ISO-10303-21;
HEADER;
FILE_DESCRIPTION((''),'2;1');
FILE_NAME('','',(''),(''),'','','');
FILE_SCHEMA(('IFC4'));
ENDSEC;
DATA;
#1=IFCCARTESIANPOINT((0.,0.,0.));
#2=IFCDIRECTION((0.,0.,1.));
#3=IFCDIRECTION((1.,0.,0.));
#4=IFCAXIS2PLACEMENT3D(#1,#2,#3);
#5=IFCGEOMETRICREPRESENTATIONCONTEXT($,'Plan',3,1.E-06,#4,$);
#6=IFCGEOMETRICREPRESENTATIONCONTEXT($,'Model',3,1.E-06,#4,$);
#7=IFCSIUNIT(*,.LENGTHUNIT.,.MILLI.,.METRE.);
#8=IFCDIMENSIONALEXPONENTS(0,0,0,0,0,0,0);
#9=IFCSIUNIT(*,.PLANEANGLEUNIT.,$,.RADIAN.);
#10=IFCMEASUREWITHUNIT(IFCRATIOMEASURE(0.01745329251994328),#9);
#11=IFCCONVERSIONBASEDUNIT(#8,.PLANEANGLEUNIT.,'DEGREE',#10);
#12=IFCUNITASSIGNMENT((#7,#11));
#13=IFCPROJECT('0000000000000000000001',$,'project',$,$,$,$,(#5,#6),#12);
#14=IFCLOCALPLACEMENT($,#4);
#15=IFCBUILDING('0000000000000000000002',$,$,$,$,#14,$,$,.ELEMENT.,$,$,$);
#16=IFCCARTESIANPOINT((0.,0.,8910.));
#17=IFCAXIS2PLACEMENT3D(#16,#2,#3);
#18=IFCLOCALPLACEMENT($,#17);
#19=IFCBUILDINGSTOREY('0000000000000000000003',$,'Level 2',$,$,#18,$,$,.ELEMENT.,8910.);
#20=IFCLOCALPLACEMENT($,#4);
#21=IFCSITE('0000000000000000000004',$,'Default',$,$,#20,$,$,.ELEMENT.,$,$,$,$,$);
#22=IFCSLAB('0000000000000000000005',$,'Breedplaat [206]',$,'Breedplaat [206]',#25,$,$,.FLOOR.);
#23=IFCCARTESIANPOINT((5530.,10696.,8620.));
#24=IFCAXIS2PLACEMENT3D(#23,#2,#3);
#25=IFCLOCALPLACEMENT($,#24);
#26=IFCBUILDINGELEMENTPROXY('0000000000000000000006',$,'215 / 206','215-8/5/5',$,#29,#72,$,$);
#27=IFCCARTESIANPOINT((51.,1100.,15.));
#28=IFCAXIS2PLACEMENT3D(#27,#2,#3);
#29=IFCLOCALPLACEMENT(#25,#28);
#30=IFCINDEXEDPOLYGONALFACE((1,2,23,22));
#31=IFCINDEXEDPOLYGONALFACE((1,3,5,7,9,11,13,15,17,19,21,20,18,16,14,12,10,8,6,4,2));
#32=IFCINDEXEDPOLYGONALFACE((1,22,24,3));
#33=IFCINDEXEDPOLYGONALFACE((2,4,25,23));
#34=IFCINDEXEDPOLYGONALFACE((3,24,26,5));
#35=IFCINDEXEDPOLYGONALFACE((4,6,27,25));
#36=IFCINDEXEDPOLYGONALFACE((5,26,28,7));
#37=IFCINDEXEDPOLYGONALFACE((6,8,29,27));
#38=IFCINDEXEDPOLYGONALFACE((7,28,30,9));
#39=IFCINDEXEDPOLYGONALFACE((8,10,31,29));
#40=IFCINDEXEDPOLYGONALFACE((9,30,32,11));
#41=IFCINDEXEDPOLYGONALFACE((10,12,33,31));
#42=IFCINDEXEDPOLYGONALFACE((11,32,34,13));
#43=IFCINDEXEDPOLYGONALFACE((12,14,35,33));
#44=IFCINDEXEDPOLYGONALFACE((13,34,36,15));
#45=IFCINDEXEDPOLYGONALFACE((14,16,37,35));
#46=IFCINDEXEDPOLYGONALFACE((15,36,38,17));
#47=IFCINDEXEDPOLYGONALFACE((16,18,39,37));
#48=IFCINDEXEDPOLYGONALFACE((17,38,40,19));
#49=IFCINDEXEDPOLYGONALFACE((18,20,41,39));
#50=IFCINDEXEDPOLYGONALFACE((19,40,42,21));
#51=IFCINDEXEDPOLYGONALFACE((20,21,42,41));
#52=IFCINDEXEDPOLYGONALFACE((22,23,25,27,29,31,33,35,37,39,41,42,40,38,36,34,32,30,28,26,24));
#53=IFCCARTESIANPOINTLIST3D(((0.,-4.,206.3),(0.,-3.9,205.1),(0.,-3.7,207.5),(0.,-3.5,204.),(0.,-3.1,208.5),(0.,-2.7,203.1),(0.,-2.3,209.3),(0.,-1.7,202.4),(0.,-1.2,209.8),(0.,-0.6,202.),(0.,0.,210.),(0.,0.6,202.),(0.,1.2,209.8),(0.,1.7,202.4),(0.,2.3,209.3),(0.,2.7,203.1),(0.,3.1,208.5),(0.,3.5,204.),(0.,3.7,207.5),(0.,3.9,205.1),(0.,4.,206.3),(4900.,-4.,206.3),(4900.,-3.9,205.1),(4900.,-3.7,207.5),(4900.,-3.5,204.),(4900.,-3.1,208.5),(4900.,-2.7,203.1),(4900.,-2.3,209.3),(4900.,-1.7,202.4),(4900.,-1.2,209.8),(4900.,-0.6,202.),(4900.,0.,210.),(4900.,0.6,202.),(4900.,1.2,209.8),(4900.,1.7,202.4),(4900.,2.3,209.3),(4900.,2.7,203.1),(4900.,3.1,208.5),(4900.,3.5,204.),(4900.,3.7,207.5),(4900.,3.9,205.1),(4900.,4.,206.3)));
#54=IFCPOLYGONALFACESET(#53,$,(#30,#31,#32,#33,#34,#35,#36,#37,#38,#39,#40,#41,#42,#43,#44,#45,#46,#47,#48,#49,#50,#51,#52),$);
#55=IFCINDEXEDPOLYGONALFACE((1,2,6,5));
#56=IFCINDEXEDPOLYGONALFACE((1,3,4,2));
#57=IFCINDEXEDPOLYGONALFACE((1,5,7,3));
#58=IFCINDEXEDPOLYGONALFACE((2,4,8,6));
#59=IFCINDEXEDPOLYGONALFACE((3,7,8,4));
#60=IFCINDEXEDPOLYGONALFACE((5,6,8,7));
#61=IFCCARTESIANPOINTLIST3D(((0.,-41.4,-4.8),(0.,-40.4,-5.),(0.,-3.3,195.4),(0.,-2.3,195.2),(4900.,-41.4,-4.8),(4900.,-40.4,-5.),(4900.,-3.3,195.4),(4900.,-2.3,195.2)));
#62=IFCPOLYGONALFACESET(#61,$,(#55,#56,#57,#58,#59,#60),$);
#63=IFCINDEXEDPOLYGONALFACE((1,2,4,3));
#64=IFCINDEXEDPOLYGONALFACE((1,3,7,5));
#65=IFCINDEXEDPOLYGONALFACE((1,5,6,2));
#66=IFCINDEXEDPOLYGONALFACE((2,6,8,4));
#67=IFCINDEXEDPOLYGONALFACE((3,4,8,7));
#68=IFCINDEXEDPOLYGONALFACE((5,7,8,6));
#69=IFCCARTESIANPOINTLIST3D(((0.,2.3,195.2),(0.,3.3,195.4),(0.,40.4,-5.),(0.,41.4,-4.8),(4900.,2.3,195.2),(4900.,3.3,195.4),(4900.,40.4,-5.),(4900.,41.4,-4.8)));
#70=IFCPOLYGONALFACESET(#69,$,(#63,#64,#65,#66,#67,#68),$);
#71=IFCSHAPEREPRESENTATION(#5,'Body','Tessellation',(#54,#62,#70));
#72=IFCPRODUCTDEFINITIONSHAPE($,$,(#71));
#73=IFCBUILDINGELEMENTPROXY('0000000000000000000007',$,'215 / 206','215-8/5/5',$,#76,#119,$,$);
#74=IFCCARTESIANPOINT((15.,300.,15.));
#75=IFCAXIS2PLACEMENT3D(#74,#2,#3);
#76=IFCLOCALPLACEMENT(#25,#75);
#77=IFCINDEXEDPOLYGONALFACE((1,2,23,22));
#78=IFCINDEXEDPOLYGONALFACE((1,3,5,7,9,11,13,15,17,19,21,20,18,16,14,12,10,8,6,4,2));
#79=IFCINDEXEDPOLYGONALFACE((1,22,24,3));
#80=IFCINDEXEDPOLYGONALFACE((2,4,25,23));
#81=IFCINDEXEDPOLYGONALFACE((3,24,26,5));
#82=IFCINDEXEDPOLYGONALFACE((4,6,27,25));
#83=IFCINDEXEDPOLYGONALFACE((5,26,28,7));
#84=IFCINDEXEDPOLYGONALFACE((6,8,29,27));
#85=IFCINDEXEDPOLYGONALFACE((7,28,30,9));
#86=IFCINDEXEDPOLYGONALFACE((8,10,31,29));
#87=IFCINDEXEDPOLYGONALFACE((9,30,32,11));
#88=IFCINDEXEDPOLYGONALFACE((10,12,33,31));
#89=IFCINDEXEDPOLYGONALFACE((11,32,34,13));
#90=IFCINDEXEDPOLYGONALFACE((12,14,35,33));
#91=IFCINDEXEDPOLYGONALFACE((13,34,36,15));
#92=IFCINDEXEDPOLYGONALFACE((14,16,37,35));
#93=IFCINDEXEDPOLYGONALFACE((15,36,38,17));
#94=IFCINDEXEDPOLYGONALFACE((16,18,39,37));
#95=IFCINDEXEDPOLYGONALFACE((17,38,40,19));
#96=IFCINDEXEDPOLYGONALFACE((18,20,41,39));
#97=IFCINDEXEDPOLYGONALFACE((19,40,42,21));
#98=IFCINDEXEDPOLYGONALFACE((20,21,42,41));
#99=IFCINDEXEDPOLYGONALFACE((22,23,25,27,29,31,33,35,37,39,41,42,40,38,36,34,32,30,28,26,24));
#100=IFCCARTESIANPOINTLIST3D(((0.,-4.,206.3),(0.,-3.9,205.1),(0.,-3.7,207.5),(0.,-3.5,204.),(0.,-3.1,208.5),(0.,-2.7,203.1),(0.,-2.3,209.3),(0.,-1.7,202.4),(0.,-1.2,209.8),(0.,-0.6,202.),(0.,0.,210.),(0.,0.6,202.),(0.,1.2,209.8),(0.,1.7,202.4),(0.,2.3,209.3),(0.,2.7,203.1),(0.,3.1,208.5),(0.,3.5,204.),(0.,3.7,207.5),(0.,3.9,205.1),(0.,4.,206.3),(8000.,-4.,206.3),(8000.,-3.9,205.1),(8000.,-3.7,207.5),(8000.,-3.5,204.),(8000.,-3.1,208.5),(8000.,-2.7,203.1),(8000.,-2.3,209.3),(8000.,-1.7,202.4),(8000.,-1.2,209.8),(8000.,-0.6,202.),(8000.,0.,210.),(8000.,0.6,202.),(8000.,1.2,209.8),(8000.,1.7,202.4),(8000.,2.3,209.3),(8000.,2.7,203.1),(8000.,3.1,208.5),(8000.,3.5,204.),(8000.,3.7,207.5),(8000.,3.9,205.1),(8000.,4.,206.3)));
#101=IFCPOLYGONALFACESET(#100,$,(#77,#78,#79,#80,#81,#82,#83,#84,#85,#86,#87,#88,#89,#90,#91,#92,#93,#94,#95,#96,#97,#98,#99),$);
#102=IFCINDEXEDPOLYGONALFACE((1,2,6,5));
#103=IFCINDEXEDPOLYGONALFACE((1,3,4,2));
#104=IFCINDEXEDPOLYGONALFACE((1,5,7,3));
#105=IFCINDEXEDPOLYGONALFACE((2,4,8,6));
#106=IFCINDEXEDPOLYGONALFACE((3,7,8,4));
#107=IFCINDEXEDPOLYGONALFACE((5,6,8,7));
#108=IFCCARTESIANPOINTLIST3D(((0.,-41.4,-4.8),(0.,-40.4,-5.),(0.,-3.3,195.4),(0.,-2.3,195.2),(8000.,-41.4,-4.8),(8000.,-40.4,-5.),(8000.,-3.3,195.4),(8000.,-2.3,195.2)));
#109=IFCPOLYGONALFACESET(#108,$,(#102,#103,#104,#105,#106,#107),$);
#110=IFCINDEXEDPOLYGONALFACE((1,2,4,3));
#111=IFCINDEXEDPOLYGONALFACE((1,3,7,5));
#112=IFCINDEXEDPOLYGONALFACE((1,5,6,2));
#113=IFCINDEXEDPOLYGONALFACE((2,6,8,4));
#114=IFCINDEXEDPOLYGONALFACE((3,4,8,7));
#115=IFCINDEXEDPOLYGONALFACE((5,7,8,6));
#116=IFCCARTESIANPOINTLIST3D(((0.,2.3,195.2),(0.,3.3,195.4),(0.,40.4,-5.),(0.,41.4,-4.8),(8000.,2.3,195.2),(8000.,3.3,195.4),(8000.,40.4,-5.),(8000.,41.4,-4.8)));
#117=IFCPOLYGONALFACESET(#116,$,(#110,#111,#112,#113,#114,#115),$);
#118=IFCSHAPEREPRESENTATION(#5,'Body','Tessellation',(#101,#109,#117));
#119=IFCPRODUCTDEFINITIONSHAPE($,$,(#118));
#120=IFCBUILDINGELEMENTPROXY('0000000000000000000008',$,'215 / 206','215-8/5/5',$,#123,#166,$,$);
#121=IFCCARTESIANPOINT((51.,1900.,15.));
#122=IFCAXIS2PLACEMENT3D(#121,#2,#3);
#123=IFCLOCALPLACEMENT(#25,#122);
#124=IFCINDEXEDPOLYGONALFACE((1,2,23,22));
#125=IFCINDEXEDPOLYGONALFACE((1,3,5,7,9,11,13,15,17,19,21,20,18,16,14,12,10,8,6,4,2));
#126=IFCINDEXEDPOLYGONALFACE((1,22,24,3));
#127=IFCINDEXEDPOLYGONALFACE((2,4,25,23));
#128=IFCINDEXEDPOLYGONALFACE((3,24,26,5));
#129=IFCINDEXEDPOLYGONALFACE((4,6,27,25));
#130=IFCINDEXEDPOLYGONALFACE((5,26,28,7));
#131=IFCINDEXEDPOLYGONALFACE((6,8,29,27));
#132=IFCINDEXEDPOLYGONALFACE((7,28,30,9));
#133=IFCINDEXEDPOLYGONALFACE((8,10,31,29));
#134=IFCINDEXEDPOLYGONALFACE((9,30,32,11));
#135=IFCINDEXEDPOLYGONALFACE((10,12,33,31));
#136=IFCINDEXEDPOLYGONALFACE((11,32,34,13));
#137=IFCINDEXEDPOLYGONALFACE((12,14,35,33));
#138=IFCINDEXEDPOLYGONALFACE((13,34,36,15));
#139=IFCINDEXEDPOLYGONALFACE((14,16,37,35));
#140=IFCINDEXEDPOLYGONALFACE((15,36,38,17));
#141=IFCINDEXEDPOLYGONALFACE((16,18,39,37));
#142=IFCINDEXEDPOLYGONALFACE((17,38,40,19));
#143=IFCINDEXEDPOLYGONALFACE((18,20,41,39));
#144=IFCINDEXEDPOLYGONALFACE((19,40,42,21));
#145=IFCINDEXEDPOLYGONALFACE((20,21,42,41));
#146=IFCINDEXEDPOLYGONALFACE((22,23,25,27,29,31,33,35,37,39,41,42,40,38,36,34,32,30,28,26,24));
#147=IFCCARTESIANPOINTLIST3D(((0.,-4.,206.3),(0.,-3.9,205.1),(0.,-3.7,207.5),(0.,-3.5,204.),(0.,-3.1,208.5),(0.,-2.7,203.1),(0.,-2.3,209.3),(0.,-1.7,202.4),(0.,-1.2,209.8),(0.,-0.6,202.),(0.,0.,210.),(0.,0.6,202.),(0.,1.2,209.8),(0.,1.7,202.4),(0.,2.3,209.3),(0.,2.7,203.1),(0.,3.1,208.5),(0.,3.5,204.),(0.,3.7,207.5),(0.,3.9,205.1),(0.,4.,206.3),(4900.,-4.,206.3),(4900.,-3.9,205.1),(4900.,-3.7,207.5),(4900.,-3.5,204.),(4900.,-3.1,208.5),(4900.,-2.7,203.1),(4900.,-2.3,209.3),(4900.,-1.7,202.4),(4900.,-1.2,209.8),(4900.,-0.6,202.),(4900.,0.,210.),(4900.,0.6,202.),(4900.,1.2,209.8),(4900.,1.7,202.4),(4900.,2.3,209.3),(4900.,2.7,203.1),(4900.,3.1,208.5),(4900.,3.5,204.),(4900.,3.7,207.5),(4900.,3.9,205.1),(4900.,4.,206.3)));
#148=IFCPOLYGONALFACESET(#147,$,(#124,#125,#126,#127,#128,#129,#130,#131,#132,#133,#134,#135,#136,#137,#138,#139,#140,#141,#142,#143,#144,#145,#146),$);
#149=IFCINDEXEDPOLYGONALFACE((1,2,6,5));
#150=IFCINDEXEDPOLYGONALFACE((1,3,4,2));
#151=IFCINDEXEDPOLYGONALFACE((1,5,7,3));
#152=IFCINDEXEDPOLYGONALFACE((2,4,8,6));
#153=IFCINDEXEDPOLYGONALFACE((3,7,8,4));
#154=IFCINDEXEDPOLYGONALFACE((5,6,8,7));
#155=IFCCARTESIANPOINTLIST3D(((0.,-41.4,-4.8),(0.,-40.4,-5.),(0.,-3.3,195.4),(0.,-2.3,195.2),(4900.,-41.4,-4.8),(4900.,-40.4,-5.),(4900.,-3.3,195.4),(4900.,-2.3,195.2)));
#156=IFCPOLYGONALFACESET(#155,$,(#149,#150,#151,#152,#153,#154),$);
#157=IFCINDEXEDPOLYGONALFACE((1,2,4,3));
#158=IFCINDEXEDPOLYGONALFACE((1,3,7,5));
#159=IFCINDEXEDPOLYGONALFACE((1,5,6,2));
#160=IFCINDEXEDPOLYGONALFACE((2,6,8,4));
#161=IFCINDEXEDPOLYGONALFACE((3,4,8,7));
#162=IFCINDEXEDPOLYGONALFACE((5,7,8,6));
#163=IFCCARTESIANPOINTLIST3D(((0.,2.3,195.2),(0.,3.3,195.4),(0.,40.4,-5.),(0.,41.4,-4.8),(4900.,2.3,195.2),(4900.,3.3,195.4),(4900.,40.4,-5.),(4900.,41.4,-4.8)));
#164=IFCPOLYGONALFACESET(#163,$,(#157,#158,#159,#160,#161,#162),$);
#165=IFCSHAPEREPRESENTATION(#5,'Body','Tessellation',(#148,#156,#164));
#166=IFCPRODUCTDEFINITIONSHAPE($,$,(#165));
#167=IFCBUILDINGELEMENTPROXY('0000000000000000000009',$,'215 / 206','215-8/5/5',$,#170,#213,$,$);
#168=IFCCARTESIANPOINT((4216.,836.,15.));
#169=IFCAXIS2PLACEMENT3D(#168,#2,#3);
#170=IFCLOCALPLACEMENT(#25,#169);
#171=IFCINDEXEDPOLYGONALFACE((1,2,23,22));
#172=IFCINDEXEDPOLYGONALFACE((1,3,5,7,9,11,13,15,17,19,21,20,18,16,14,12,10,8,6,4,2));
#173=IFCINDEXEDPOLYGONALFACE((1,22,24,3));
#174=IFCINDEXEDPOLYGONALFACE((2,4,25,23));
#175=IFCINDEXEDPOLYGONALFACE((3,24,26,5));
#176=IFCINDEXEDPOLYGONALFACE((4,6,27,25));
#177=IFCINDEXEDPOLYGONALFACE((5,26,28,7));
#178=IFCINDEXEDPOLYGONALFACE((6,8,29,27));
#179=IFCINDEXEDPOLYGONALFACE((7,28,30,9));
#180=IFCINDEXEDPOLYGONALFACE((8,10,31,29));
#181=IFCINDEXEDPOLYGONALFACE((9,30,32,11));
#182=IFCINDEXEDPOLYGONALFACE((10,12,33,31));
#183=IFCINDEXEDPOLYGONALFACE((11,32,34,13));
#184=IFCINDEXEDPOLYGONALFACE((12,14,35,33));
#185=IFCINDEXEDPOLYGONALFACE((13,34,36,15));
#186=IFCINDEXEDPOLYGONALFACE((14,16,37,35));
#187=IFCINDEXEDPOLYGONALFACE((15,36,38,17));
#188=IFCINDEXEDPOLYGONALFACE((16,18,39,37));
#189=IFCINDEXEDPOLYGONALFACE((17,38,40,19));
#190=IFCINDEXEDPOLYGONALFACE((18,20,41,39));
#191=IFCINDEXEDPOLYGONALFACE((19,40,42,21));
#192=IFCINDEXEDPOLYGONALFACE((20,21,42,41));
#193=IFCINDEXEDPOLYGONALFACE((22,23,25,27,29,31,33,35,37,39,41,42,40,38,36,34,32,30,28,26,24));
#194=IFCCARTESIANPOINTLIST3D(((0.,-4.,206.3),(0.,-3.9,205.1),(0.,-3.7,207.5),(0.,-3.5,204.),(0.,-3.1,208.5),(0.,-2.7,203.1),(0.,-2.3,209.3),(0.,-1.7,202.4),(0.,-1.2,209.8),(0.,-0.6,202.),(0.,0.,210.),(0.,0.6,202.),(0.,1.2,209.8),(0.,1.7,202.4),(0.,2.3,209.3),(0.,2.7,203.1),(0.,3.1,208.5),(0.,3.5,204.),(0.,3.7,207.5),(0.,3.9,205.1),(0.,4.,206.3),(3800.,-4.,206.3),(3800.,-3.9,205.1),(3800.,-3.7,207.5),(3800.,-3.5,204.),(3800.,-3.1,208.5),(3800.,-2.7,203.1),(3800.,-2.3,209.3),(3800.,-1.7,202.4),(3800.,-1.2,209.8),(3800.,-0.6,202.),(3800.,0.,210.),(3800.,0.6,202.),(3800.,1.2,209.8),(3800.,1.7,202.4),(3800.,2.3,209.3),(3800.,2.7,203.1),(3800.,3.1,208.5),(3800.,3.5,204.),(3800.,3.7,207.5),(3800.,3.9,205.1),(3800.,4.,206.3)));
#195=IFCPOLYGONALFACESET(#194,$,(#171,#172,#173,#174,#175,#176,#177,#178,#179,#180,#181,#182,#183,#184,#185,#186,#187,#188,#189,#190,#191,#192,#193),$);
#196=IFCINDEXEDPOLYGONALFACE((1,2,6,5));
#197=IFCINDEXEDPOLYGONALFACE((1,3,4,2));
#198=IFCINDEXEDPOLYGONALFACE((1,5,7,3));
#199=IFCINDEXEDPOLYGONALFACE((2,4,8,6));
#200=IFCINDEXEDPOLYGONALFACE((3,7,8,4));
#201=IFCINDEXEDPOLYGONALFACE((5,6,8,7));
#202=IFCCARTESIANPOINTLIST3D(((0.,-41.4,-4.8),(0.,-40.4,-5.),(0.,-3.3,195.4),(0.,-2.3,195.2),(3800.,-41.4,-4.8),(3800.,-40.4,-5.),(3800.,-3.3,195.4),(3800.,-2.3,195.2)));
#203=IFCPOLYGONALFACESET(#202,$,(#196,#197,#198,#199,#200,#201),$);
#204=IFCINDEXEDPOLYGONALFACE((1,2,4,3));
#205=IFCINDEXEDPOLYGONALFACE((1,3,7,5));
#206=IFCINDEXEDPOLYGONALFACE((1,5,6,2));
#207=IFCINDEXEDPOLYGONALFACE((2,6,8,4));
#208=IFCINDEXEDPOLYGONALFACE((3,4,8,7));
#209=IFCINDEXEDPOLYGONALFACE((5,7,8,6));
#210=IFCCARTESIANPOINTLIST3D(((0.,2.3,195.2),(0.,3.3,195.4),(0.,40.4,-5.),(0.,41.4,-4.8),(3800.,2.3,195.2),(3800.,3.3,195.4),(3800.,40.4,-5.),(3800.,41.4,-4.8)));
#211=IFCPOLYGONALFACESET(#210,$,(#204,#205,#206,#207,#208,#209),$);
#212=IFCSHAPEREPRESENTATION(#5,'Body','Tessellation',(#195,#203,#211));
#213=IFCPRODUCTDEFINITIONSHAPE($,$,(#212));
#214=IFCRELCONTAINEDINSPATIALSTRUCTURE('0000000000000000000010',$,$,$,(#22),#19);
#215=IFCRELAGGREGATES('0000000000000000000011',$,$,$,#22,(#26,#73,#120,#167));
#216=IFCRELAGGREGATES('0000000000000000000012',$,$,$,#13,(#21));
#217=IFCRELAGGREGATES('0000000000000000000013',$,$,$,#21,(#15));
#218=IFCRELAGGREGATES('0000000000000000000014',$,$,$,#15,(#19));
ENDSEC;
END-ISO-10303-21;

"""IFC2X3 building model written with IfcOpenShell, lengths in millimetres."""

from ifc_helpers import new_model, entity, si_unit, converted_unit, frame, origin_with_axes, origin_2d_with_axis, place, context, project, spatial, rectangle, circle, extrude, element, aggregate, save


model = new_model("IFC2X3")

# Units and contexts
plan_context = context("Plan", 3, precision=1e-06, world=origin_with_axes())
model_context = context("Model", 3, precision=1e-06, world=origin_with_axes())
ifc_project = project(units=[si_unit("LENGTHUNIT", "METRE", prefix="MILLI"), converted_unit("PLANEANGLEUNIT", "DEGREE", entity("IfcRatioMeasure", 0.01745329251994328), si_unit("PLANEANGLEUNIT", "RADIAN"), dimensions=[0, 0, 0, 0, 0, 0, 0])], contexts=[plan_context, model_context])

# Site, building, storey
site_placement = place(None, origin_with_axes())
site = spatial("IfcSite", under=ifc_project, at=site_placement, Name="Default", CompositionType="ELEMENT")
building_placement = place(None, origin_with_axes())
building = spatial("IfcBuilding", under=site, at=building_placement, CompositionType="ELEMENT")
storey_placement = place(None, frame((0.0, 0.0, 8910.0), z_axis=(0.0, 0.0, 1.0), x_axis=(1.0, 0.0, 0.0)))
storey = spatial("IfcBuildingStorey", under=building, at=storey_placement, Name="Level 2", CompositionType="ELEMENT", Elevation=8910.0)

# Slab, building element proxies
slab_1_placement = place(None, frame((5530.0, 10696.0, 8620.0), z_axis=(0.0, 0.0, 1.0), x_axis=(1.0, 0.0, 0.0)))
slab_1 = element("IfcSlab", 1, at=slab_1_placement, inside=storey, Name="Breedplaat [206]", ObjectType="Breedplaat [206]", PredefinedType="FLOOR")
proxy_1_placement = place(slab_1_placement, frame((51.0, 1100.0, 15.0), z_axis=(0.0, 0.0, 1.0), x_axis=(1.0, 0.0, 0.0)))
proxy_1 = element("IfcBuildingElementProxy", 2, at=proxy_1_placement, Name="215 / 206", Description="215-8/5/5", context=plan_context, shape_type="SweptSolid", body=[
    extrude(circle(Radius=4.0, at=origin_2d_with_axis()), frame((0.0, 0.0, 206.0), z_axis=(1.0, 0.0, 0.0), x_axis=(0.0, 0.0, 1.0)), (0.0, 0.0, 1.0), 4900.0),
    extrude(rectangle(XDim=203.8, YDim=1.0, at=origin_2d_with_axis()), frame((0.0, -21.9, 95.2), z_axis=(1.0, 0.0, 0.0), x_axis=(0.0, 0.187112, 0.982339)), (0.0, 0.0, 1.0), 4900.0),
    extrude(rectangle(XDim=203.8, YDim=1.0, at=origin_2d_with_axis()), frame((0.0, 21.9, 95.2), z_axis=(1.0, 0.0, 0.0), x_axis=(0.0, -0.187112, 0.982339)), (0.0, 0.0, 1.0), 4900.0),
])
proxy_2_placement = place(slab_1_placement, frame((15.0, 300.0, 15.0), z_axis=(0.0, 0.0, 1.0), x_axis=(1.0, 0.0, 0.0)))
proxy_2 = element("IfcBuildingElementProxy", 3, at=proxy_2_placement, Name="215 / 206", Description="215-8/5/5", context=plan_context, shape_type="SweptSolid", body=[
    extrude(circle(Radius=4.0, at=origin_2d_with_axis()), frame((0.0, 0.0, 206.0), z_axis=(1.0, 0.0, 0.0), x_axis=(0.0, 0.0, 1.0)), (0.0, 0.0, 1.0), 8000.0),
    extrude(rectangle(XDim=203.8, YDim=1.0, at=origin_2d_with_axis()), frame((0.0, -21.9, 95.2), z_axis=(1.0, 0.0, 0.0), x_axis=(0.0, 0.187112, 0.982339)), (0.0, 0.0, 1.0), 8000.0),
    extrude(rectangle(XDim=203.8, YDim=1.0, at=origin_2d_with_axis()), frame((0.0, 21.9, 95.2), z_axis=(1.0, 0.0, 0.0), x_axis=(0.0, -0.187112, 0.982339)), (0.0, 0.0, 1.0), 8000.0),
])
proxy_3_placement = place(slab_1_placement, frame((51.0, 1900.0, 15.0), z_axis=(0.0, 0.0, 1.0), x_axis=(1.0, 0.0, 0.0)))
proxy_3 = element("IfcBuildingElementProxy", 4, at=proxy_3_placement, Name="215 / 206", Description="215-8/5/5", context=plan_context, shape_type="SweptSolid", body=[
    extrude(circle(Radius=4.0, at=origin_2d_with_axis()), frame((0.0, 0.0, 206.0), z_axis=(1.0, 0.0, 0.0), x_axis=(0.0, 0.0, 1.0)), (0.0, 0.0, 1.0), 4900.0),
    extrude(rectangle(XDim=203.8, YDim=1.0, at=origin_2d_with_axis()), frame((0.0, -21.9, 95.2), z_axis=(1.0, 0.0, 0.0), x_axis=(0.0, 0.187112, 0.982339)), (0.0, 0.0, 1.0), 4900.0),
    extrude(rectangle(XDim=203.8, YDim=1.0, at=origin_2d_with_axis()), frame((0.0, 21.9, 95.2), z_axis=(1.0, 0.0, 0.0), x_axis=(0.0, -0.187112, 0.982339)), (0.0, 0.0, 1.0), 4900.0),
])
proxy_4_placement = place(slab_1_placement, frame((4216.0, 836.0, 15.0), z_axis=(0.0, 0.0, 1.0), x_axis=(1.0, 0.0, 0.0)))
proxy_4 = element("IfcBuildingElementProxy", 5, at=proxy_4_placement, Name="215 / 206", Description="215-8/5/5", context=plan_context, shape_type="SweptSolid", body=[
    extrude(circle(Radius=4.0, at=origin_2d_with_axis()), frame((0.0, 0.0, 206.0), z_axis=(1.0, 0.0, 0.0), x_axis=(0.0, 0.0, 1.0)), (0.0, 0.0, 1.0), 3800.0),
    extrude(rectangle(XDim=203.8, YDim=1.0, at=origin_2d_with_axis()), frame((0.0, -21.9, 95.2), z_axis=(1.0, 0.0, 0.0), x_axis=(0.0, 0.187112, 0.982339)), (0.0, 0.0, 1.0), 3800.0),
    extrude(rectangle(XDim=203.8, YDim=1.0, at=origin_2d_with_axis()), frame((0.0, 21.9, 95.2), z_axis=(1.0, 0.0, 0.0), x_axis=(0.0, -0.187112, 0.982339)), (0.0, 0.0, 1.0), 3800.0),
])
aggregate(slab_1, [proxy_1, proxy_2, proxy_3, proxy_4])

save(model, "model.ifc")
